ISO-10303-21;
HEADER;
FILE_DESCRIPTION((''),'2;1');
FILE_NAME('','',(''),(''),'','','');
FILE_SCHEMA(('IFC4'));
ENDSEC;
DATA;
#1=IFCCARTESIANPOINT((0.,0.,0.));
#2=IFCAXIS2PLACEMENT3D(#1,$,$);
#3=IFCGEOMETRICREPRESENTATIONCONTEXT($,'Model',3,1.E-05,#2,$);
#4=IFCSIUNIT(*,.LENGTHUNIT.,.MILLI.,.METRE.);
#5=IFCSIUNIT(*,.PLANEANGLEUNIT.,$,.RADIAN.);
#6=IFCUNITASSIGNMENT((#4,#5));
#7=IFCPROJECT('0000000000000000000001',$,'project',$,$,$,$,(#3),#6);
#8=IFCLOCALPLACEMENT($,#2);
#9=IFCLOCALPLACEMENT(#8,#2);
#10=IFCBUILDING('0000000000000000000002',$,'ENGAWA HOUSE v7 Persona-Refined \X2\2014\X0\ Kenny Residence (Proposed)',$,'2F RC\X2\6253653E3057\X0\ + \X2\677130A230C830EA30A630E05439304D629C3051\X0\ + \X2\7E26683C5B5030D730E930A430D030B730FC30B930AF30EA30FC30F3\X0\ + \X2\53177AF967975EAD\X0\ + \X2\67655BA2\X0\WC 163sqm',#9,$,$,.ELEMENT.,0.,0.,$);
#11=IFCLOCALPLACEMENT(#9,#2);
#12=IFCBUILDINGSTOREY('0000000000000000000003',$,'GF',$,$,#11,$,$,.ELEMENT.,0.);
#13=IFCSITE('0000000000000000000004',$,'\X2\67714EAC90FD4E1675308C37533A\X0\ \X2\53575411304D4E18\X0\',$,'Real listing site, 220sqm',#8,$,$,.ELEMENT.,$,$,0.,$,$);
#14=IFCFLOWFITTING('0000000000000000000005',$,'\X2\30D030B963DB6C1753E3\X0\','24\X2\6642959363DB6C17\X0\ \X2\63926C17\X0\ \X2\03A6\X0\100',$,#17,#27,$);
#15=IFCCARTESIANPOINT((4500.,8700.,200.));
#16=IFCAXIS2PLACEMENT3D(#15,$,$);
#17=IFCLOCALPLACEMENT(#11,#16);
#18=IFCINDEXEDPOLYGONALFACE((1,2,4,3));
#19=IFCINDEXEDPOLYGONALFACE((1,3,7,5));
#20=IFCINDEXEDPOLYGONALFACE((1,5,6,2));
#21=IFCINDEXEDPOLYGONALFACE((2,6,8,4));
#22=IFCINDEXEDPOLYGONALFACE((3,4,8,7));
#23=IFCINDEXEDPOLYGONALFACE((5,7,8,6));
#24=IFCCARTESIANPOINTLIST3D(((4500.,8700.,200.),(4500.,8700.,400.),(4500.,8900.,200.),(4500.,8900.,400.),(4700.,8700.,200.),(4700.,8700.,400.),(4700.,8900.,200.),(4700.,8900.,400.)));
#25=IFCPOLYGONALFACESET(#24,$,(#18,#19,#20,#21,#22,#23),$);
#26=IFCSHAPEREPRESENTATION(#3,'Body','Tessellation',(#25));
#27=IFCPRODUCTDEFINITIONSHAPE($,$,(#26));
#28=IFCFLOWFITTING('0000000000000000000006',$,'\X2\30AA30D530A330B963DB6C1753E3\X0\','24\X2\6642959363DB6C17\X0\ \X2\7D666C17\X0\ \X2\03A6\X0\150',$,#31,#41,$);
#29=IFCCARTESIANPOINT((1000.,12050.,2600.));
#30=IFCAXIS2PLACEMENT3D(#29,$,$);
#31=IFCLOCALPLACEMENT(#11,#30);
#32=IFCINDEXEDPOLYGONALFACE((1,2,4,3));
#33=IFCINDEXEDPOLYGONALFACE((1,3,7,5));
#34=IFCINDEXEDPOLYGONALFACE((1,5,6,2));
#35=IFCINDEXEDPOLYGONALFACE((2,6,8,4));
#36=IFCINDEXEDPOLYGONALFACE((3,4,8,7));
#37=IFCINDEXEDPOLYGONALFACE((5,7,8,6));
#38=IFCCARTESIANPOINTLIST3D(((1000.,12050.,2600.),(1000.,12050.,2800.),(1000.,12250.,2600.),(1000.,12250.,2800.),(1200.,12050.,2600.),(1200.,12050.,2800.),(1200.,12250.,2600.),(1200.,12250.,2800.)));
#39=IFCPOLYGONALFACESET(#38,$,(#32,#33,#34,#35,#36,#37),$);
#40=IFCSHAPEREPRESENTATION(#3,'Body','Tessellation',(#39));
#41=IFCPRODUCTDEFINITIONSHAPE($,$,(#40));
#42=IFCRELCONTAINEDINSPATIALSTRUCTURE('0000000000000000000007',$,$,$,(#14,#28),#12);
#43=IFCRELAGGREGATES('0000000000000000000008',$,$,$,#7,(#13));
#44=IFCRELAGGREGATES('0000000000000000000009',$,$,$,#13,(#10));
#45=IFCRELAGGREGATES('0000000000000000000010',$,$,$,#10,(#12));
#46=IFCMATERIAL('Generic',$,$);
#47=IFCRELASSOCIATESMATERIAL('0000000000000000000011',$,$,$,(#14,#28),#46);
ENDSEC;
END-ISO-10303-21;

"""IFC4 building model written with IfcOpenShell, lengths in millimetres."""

from ifc_helpers import new_model, si_unit, frame, frame_2d, origin, place, context, project, spatial, rectangle, extrude, material, element, save


model = new_model("IFC4")

# Units and contexts
model_context = context("Model", 3, precision=1e-05, world=origin())
ifc_project = project(units=[si_unit("LENGTHUNIT", "METRE", prefix="MILLI"), si_unit("PLANEANGLEUNIT", "RADIAN")], contexts=[model_context])

# Site, building, storey
site_placement = place(None, origin())
site = spatial("IfcSite", under=ifc_project, at=site_placement, Name="東京都世田谷区 南向き丘", ObjectType="Real listing site, 220sqm", CompositionType="ELEMENT", RefElevation=0.0)
building_placement = place(site_placement, origin())
building = spatial("IfcBuilding", under=site, at=building_placement, Name="ENGAWA HOUSE v7 Persona-Refined — Kenny Residence (Proposed)", ObjectType="2F RC打放し + 東アトリウム吹き抜け + 縦格子プライバシースクリーン + 北竹林庭 + 来客WC 163sqm", CompositionType="ELEMENT", ElevationOfRefHeight=0.0, ElevationOfTerrain=0.0)
storey_placement = place(building_placement, origin())
storey = spatial("IfcBuildingStorey", under=building, at=storey_placement, Name="GF", CompositionType="ELEMENT", Elevation=0.0)

# Shared definitions
ifc_material_1 = material(Name="Generic")

# Flow fittings
flow_fitting_1_placement = place(storey_placement, frame((4500.0, 8700.0, 200.0)))
element("IfcFlowFitting", 1, at=flow_fitting_1_placement, inside=storey, material=ifc_material_1, Name="バス換気口", Description="24時間換気 排気 Φ100", context=model_context, shape_type="SweptSolid", body=[
    extrude(rectangle(XDim=200.0, YDim=200.0, at=frame_2d((100.0, 100.0))), frame((4500.0, 8700.0, 200.0)), (0.0, 0.0, 1.0), 200.0),
])
flow_fitting_2_placement = place(storey_placement, frame((1000.0, 12050.0, 2600.0)))
element("IfcFlowFitting", 2, at=flow_fitting_2_placement, inside=storey, material=ifc_material_1, Name="オフィス換気口", Description="24時間換気 給気 Φ150", context=model_context, shape_type="SweptSolid", body=[
    extrude(rectangle(XDim=200.0, YDim=200.0, at=frame_2d((100.0, 100.0))), frame((1000.0, 12050.0, 2600.0)), (0.0, 0.0, 1.0), 200.0),
])

save(model, "model.ifc")
